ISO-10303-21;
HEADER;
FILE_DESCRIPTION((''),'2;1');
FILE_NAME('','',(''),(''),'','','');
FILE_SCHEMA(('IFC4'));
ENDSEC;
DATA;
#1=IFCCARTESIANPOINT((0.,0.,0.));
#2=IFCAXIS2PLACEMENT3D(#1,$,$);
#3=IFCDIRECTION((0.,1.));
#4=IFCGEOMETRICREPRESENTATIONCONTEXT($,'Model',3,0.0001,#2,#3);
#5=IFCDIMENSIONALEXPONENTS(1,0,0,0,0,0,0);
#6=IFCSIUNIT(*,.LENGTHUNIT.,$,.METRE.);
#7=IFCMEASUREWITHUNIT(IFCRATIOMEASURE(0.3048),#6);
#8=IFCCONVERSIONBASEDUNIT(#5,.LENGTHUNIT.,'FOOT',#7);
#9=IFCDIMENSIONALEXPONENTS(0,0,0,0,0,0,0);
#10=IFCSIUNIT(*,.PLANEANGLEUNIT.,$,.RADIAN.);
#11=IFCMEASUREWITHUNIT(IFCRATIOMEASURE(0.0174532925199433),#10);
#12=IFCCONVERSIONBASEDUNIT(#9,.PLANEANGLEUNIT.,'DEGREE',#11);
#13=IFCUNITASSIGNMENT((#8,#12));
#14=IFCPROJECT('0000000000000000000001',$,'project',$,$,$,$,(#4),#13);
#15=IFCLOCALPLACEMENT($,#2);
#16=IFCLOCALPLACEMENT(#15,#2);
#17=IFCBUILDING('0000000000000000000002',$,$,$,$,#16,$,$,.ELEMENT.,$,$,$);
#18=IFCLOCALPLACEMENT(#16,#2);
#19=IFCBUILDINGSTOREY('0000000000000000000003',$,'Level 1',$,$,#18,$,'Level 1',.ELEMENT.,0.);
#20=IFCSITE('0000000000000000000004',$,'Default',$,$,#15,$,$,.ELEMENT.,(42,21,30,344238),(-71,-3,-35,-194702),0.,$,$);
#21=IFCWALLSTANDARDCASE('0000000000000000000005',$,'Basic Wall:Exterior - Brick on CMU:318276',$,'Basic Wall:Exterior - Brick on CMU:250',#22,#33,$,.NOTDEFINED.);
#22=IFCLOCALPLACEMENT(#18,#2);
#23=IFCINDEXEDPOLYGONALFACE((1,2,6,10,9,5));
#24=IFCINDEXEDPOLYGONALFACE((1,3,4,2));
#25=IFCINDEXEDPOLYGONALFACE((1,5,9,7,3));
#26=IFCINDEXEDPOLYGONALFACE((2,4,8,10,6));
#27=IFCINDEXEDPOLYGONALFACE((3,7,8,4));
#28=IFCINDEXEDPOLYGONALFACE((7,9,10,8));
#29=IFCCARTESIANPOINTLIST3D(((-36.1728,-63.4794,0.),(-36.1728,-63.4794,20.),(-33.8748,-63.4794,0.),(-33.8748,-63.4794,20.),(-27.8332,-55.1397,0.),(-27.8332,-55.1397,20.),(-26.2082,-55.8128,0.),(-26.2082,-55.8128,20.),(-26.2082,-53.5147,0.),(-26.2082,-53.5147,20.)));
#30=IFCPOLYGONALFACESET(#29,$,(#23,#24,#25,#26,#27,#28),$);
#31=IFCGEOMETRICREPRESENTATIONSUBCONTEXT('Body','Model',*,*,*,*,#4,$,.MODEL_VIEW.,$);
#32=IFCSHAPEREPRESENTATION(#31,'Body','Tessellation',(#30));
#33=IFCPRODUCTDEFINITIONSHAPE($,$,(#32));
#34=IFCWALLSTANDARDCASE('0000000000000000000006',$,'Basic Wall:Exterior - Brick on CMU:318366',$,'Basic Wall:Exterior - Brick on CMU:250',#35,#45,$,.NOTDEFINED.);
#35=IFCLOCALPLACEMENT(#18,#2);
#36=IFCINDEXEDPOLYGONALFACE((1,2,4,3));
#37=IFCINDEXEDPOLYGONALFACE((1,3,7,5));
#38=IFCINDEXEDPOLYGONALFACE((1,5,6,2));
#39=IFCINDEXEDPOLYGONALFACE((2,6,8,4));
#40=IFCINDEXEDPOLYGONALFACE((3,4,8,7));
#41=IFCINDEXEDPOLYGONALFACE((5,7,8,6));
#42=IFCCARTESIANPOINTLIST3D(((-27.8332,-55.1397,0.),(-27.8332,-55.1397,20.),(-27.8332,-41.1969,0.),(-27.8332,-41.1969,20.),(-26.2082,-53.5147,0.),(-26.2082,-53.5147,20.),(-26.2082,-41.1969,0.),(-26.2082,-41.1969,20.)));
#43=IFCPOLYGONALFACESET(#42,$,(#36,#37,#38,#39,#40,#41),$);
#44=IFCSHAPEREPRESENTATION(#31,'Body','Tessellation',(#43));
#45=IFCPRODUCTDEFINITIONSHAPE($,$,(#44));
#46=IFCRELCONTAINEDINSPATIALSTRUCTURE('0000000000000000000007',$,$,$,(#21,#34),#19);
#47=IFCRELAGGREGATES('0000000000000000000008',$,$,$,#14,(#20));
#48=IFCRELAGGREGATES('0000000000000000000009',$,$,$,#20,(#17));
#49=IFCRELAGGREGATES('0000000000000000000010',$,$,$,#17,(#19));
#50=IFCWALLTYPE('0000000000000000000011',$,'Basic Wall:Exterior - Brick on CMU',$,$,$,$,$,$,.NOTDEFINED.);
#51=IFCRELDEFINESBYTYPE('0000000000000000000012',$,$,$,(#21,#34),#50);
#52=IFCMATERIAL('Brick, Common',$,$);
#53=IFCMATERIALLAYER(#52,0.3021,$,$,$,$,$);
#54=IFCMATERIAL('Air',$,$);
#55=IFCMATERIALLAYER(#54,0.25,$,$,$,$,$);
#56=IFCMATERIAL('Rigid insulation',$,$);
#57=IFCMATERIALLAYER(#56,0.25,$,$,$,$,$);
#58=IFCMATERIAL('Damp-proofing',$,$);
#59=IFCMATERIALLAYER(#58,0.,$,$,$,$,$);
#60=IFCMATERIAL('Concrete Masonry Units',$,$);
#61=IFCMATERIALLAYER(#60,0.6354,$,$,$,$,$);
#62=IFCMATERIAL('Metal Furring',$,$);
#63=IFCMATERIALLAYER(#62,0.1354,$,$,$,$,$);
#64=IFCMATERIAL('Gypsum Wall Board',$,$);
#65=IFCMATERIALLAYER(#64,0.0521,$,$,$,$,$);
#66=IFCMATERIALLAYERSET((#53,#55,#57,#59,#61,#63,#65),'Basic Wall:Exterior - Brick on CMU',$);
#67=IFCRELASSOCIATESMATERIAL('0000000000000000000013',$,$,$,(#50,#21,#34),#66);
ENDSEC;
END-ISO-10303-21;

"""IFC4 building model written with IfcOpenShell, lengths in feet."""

from ifc_helpers import new_model, entity, si_unit, converted_unit, direction, frame, origin, place, context, subcontext, project, spatial, polyline, outline, extrude, material, layer, layer_set, layer_usage, type_object, element, save


model = new_model("IFC4")

# Units and contexts
model_context = context("Model", 3, precision=0.0001, world=origin(), true_north=direction((0.0, 1.0)))
body_context = subcontext(model_context, "Body", "Model", "MODEL_VIEW")
ifc_project = project(units=[converted_unit("LENGTHUNIT", "FOOT", entity("IfcRatioMeasure", 0.3048), si_unit("LENGTHUNIT", "METRE"), dimensions=[1, 0, 0, 0, 0, 0, 0]), converted_unit("PLANEANGLEUNIT", "DEGREE", entity("IfcRatioMeasure", 0.0174532925199433), si_unit("PLANEANGLEUNIT", "RADIAN"), dimensions=[0, 0, 0, 0, 0, 0, 0])], contexts=[model_context])

# Site, building, storey
site_placement = place(None, origin())
site = spatial("IfcSite", under=ifc_project, at=site_placement, Name="Default", CompositionType="ELEMENT", RefLatitude=(42, 21, 30, 344238), RefLongitude=(-71, -3, -35, -194702), RefElevation=0.0)
building_placement = place(site_placement, origin())
building = spatial("IfcBuilding", under=site, at=building_placement, CompositionType="ELEMENT")
storey_placement = place(building_placement, origin())
storey = spatial("IfcBuildingStorey", under=building, at=storey_placement, Name="Level 1", LongName="Level 1", CompositionType="ELEMENT", Elevation=0.0)

# Shared definitions
ifc_material_1 = material(Name="Brick, Common")
ifc_layer_1 = layer(ifc_material_1, 0.3021)
ifc_material_2 = material(Name="Air")
ifc_layer_2 = layer(ifc_material_2, 0.25)
ifc_material_3 = material(Name="Rigid insulation")
ifc_layer_3 = layer(ifc_material_3, 0.25)
ifc_material_4 = material(Name="Damp-proofing")
ifc_layer_4 = layer(ifc_material_4, 0.0)
ifc_material_5 = material(Name="Concrete Masonry Units")
ifc_layer_5 = layer(ifc_material_5, 0.6354)
ifc_material_6 = material(Name="Metal Furring")
ifc_layer_6 = layer(ifc_material_6, 0.1354)
ifc_material_7 = material(Name="Gypsum Wall Board")
ifc_layer_7 = layer(ifc_material_7, 0.0521)
ifc_layer_set = layer_set([ifc_layer_1, ifc_layer_2, ifc_layer_3, ifc_layer_4, ifc_layer_5, ifc_layer_6, ifc_layer_7], Name="Basic Wall:Exterior - Brick on CMU")
wall_type = type_object("IfcWallType", Name="Basic Wall:Exterior - Brick on CMU", PredefinedType="NOTDEFINED", material=ifc_layer_set)

# Walls
ifc_layer_usage_1 = layer_usage(ifc_layer_set, "AXIS2", "NEGATIVE", 0.8125)
wall_1_placement = place(storey_placement, frame((-35.5983, -64.0539, 0.0), z_axis=(0.0, 0.0, 1.0), x_axis=(0.707107, 0.707107, 0.0)))
element("IfcWallStandardCase", 1, at=wall_1_placement, inside=storey, type_object=wall_type, material=ifc_layer_usage_1, Name="Basic Wall:Exterior - Brick on CMU:318276", ObjectType="Basic Wall:Exterior - Brick on CMU:250", PredefinedType="NOTDEFINED", context=body_context, shape_type="SweptSolid", body=[
    extrude(outline(polyline([(12.4672, -0.8125), (14.0922, 0.8125), (11.7941, 0.8125), (0.0, 0.8125), (1.625, -0.8125), (12.4672, -0.8125)])), origin(), (0.0, 0.0, 1.0), 20.0),
])
ifc_layer_usage_2 = layer_usage(ifc_layer_set, "AXIS2", "NEGATIVE", 0.8125)
wall_2_placement = place(storey_placement, frame((-27.0207, -55.1397, 0.0), z_axis=(0.0, 0.0, 1.0), x_axis=(0.0, 1.0, 0.0)))
element("IfcWallStandardCase", 2, at=wall_2_placement, inside=storey, type_object=wall_type, material=ifc_layer_usage_2, Name="Basic Wall:Exterior - Brick on CMU:318366", ObjectType="Basic Wall:Exterior - Brick on CMU:250", PredefinedType="NOTDEFINED", context=body_context, shape_type="SweptSolid", body=[
    extrude(outline(polyline([(13.9428, -0.8125), (13.9428, 0.8125), (0.0, 0.8125), (1.625, -0.8125), (13.9428, -0.8125)])), origin(), (0.0, 0.0, 1.0), 20.0),
])

save(model, "model.ifc")
